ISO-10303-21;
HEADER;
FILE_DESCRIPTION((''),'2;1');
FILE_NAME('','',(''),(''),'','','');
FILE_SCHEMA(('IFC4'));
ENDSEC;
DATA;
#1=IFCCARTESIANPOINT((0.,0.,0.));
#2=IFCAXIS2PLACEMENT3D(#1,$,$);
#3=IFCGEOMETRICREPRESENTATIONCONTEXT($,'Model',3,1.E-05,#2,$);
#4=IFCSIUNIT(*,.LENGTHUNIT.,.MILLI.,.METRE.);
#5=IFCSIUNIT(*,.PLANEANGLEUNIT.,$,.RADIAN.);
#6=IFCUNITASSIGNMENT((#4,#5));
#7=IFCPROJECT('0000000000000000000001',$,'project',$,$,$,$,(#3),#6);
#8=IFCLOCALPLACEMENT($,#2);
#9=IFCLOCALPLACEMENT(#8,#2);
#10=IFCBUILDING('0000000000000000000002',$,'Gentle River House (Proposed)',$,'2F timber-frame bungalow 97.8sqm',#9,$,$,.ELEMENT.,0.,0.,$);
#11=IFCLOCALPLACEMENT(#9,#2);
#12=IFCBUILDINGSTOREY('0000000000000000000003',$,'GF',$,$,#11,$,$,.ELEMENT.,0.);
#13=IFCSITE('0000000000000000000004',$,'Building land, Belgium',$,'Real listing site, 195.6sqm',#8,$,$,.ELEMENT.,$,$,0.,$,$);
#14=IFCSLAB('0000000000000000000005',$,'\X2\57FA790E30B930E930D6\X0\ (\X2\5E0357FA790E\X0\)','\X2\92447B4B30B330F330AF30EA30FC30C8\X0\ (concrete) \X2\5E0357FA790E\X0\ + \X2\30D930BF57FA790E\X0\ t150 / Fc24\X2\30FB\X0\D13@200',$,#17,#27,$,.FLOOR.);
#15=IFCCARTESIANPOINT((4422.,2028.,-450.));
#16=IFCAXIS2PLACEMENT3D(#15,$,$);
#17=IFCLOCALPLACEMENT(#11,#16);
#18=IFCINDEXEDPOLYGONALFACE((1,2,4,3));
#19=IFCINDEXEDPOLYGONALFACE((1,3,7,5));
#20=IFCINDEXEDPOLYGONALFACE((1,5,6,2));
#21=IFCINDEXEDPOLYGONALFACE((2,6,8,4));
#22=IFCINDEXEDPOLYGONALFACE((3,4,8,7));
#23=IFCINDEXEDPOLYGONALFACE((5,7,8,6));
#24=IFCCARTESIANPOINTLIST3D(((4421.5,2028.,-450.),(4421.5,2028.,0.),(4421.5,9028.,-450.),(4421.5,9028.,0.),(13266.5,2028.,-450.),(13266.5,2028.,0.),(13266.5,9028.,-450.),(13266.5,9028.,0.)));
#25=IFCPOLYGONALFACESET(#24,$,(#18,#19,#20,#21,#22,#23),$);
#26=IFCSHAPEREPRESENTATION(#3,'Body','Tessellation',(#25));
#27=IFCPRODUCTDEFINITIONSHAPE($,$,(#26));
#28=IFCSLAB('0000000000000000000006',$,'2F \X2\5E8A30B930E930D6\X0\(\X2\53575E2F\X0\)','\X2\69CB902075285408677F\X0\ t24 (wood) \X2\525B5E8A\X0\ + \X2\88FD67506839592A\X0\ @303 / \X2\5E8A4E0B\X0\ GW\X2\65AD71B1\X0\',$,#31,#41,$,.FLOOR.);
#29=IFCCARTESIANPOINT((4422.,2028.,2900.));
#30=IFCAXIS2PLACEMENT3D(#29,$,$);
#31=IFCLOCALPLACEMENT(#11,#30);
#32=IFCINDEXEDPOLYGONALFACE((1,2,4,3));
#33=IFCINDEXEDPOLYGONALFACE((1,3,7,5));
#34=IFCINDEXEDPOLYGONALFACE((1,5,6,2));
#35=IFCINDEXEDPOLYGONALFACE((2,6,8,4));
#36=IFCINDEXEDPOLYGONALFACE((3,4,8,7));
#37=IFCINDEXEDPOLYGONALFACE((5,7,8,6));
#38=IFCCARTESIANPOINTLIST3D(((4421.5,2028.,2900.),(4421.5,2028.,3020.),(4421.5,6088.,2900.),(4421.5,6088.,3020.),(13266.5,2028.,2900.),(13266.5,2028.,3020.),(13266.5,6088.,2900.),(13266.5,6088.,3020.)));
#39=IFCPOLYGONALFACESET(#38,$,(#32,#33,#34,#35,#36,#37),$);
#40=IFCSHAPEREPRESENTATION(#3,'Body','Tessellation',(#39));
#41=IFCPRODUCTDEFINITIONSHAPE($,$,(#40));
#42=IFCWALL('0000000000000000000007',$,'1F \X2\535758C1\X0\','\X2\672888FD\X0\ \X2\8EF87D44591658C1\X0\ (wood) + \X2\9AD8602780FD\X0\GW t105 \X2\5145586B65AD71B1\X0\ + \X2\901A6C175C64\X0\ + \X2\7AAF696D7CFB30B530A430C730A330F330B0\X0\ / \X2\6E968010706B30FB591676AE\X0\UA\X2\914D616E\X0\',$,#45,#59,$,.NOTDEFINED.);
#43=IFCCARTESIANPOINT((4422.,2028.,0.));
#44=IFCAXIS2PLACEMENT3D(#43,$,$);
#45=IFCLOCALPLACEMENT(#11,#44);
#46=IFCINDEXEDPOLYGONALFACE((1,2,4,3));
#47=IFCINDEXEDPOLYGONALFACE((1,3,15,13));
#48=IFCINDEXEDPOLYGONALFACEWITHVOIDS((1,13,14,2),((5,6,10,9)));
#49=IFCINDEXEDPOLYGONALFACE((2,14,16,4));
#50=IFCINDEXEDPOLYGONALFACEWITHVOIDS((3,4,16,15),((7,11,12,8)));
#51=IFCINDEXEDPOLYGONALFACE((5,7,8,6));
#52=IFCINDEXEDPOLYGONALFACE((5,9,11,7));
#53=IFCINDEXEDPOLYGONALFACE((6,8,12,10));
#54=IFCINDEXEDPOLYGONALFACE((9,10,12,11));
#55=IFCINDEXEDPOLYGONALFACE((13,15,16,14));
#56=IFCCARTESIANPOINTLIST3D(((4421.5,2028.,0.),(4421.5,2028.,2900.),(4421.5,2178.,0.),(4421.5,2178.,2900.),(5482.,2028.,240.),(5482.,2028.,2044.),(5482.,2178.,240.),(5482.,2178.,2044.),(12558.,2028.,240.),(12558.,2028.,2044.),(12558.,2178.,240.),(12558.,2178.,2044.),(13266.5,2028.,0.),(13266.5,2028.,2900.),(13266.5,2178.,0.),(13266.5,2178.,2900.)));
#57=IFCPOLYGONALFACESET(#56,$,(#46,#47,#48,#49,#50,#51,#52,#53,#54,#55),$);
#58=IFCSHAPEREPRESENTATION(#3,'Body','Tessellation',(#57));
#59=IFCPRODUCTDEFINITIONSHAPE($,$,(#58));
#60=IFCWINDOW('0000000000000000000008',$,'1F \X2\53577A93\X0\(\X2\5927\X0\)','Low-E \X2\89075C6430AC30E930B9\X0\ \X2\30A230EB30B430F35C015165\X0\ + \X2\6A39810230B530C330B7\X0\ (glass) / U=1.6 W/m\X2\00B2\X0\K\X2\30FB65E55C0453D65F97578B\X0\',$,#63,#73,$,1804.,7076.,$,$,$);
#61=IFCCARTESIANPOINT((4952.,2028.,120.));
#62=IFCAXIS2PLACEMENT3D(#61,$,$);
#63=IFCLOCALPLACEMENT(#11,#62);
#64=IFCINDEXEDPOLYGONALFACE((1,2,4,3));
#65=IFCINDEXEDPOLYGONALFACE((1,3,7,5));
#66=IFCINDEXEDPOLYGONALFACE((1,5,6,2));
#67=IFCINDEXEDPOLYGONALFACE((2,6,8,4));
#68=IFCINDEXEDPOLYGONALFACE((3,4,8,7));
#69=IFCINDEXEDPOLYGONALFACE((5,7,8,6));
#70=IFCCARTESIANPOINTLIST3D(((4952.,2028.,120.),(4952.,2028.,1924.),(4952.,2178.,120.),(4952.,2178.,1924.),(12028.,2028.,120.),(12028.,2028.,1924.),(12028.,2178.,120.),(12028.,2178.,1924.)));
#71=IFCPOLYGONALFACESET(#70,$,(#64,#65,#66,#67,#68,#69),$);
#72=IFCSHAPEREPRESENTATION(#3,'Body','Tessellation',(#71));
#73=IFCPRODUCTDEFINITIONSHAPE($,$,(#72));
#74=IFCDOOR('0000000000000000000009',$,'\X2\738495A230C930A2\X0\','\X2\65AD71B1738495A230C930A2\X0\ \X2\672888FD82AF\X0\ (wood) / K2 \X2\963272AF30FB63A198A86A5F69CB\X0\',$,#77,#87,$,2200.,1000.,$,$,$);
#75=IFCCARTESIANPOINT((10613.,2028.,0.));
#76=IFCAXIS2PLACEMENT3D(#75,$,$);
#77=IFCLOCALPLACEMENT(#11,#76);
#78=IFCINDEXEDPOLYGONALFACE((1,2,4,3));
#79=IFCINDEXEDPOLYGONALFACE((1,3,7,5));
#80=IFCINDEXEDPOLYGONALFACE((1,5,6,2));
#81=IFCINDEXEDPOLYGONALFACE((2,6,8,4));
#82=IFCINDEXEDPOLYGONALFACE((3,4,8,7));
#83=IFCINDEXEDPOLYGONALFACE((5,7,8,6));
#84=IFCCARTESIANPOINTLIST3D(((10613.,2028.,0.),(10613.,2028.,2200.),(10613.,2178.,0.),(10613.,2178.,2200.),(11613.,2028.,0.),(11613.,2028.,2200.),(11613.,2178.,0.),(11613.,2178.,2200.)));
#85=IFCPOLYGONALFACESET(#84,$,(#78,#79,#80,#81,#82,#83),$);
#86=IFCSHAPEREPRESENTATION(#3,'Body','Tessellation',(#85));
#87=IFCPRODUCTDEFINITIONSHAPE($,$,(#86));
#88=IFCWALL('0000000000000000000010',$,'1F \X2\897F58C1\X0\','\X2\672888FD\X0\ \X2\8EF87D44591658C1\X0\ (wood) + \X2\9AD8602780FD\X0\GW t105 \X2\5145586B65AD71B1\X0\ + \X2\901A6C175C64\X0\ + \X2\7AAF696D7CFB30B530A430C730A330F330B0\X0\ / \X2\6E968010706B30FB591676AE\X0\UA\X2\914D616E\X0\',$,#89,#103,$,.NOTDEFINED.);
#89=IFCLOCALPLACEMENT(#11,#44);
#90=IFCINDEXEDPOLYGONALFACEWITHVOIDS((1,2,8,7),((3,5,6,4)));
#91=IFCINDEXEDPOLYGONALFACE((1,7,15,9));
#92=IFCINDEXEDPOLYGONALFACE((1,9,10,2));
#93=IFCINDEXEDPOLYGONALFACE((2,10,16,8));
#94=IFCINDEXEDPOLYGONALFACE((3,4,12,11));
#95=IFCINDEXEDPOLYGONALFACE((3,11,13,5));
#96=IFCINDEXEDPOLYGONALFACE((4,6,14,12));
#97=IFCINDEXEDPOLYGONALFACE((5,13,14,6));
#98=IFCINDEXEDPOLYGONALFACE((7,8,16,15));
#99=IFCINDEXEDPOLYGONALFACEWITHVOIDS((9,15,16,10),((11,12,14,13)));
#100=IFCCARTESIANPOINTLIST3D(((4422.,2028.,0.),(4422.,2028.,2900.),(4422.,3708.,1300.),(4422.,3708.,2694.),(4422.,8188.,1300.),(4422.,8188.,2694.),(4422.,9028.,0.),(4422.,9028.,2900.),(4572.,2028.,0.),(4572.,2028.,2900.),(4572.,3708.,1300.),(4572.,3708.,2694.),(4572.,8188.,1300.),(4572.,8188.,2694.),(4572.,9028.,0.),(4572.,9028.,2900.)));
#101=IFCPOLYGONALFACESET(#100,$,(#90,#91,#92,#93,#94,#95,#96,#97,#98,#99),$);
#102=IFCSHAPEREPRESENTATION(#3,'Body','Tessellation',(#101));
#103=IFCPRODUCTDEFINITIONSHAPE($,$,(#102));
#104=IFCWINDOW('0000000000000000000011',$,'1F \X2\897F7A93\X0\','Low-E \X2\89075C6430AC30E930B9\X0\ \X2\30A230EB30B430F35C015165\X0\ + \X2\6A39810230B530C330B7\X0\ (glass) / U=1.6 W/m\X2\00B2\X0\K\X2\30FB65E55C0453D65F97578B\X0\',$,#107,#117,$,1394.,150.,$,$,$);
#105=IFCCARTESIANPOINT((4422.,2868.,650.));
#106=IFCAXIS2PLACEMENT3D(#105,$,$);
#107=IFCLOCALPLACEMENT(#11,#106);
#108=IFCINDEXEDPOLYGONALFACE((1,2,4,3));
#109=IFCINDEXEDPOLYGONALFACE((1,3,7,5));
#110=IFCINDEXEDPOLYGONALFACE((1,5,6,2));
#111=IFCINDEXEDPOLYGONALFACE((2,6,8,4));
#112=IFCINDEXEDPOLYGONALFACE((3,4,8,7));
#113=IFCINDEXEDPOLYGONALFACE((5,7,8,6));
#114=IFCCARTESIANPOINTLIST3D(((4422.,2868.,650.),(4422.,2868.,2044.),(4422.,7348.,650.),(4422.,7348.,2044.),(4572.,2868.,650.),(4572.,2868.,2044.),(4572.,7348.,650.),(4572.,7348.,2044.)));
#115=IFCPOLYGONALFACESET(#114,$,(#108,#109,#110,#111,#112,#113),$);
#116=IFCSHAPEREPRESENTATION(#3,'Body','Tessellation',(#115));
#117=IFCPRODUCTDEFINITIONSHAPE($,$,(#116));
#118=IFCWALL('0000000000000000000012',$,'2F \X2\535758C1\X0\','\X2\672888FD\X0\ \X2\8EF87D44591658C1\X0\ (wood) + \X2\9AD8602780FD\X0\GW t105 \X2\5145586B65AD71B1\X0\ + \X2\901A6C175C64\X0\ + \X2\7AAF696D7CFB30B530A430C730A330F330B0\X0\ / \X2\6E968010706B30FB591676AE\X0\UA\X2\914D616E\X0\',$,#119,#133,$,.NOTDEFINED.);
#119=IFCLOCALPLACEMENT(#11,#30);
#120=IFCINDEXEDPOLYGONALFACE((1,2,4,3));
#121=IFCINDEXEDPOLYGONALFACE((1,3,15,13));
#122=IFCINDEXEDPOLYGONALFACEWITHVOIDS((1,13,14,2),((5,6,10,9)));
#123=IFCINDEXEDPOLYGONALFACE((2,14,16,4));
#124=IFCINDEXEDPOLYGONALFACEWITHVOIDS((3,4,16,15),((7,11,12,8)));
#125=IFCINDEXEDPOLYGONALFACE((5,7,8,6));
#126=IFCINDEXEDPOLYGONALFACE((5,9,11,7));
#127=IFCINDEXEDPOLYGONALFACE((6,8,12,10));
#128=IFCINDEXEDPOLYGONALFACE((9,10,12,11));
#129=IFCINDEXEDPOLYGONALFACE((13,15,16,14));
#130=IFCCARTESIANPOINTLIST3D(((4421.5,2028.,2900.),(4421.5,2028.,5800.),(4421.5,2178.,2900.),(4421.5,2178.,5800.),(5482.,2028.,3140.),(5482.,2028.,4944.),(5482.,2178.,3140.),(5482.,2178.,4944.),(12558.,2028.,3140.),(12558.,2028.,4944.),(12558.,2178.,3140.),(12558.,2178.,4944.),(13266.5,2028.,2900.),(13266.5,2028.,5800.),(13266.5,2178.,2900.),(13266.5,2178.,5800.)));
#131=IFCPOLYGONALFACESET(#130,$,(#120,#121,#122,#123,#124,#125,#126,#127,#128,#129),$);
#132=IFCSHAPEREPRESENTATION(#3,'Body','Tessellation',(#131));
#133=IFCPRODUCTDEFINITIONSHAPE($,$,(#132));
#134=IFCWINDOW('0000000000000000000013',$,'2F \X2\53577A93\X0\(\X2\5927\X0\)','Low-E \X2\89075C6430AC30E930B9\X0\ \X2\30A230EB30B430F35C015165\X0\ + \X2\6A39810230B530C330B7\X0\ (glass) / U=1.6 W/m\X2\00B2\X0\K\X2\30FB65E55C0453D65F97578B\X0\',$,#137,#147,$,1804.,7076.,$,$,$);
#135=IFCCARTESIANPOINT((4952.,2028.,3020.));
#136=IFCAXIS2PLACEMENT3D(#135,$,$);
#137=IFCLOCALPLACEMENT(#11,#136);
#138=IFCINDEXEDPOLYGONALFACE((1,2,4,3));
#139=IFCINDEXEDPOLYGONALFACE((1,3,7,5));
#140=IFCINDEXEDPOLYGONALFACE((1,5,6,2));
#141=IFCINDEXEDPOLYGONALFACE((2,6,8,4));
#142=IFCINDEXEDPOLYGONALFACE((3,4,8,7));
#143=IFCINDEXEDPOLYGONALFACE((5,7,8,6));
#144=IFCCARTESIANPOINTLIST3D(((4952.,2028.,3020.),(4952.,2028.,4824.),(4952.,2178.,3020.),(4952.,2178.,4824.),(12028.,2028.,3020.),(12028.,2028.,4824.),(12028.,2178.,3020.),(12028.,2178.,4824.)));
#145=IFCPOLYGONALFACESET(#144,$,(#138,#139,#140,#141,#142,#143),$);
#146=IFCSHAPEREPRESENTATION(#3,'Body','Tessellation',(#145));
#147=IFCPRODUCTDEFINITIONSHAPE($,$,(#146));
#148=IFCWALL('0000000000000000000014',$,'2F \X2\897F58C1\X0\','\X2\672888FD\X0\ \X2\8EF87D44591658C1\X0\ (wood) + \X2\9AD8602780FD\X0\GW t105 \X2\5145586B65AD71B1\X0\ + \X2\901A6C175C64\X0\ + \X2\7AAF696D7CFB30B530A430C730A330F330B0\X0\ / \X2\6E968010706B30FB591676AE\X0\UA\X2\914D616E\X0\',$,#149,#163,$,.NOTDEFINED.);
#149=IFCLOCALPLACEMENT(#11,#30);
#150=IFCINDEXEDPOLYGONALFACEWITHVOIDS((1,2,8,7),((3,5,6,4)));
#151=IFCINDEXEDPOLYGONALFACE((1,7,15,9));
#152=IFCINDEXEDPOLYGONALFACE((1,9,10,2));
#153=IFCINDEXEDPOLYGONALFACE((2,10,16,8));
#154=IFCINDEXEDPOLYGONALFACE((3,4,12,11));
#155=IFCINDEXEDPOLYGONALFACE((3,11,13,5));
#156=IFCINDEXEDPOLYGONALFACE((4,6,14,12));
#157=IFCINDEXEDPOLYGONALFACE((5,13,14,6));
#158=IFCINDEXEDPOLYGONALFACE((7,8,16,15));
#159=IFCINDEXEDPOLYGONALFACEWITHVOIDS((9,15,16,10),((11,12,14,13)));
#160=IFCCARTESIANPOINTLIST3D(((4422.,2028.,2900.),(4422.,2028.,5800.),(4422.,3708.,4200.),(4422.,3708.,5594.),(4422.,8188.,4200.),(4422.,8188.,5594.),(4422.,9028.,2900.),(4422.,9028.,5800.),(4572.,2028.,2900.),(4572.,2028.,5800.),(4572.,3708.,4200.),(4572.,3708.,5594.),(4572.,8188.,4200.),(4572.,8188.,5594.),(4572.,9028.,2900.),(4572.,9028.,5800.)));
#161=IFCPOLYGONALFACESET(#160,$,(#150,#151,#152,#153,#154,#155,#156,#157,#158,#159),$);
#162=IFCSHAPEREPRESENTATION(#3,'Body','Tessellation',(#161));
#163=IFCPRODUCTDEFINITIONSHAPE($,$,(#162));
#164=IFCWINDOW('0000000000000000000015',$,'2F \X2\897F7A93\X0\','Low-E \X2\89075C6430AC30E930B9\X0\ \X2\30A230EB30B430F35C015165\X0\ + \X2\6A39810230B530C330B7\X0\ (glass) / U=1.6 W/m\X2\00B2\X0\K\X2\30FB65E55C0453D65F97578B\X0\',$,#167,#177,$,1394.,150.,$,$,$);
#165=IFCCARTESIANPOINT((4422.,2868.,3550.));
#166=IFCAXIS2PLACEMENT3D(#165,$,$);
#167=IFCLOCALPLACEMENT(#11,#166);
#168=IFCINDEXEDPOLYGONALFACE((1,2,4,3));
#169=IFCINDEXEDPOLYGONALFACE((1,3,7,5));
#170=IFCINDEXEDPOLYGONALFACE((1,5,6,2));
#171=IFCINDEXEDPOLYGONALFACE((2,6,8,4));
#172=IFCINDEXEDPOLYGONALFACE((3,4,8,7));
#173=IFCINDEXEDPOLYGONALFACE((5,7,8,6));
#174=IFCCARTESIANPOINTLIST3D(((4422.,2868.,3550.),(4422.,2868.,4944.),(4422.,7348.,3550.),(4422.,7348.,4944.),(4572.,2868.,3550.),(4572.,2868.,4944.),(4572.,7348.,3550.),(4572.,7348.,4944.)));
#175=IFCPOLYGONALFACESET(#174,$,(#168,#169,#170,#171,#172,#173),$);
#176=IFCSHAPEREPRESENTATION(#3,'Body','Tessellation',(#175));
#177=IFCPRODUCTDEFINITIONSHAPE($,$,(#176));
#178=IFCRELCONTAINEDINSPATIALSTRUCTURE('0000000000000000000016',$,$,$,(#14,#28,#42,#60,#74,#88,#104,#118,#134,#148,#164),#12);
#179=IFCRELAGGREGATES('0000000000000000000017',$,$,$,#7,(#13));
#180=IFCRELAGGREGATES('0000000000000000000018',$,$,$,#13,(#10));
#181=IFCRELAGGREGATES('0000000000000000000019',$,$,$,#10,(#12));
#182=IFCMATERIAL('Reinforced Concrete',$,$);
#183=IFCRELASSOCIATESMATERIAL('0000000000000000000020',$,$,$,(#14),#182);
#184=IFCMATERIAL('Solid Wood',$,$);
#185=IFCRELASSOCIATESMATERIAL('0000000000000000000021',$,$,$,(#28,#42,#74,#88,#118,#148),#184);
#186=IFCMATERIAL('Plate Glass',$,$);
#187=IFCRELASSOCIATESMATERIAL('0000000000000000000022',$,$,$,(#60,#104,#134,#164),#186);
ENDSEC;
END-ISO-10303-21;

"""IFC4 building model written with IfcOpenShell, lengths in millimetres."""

from ifc_helpers import new_model, si_unit, frame, frame_2d, origin, place, context, project, spatial, rectangle, extrude, material, element, fill, save


model = new_model("IFC4")

# Units and contexts
model_context = context("Model", 3, precision=1e-05, world=origin())
ifc_project = project(units=[si_unit("LENGTHUNIT", "METRE", prefix="MILLI"), si_unit("PLANEANGLEUNIT", "RADIAN")], contexts=[model_context])

# Site, building, storey
site_placement = place(None, origin())
site = spatial("IfcSite", under=ifc_project, at=site_placement, Name="Building land, Belgium", ObjectType="Real listing site, 195.6sqm", CompositionType="ELEMENT", RefElevation=0.0)
building_placement = place(site_placement, origin())
building = spatial("IfcBuilding", under=site, at=building_placement, Name="Gentle River House (Proposed)", ObjectType="2F timber-frame bungalow 97.8sqm", CompositionType="ELEMENT", ElevationOfRefHeight=0.0, ElevationOfTerrain=0.0)
storey_placement = place(building_placement, origin())
storey = spatial("IfcBuildingStorey", under=building, at=storey_placement, Name="GF", CompositionType="ELEMENT", Elevation=0.0)

# Slabs
ifc_material_1 = material(Name="Reinforced Concrete")
slab_1_placement = place(storey_placement, frame((4422.0, 2028.0, -450.0)))
element("IfcSlab", 1, at=slab_1_placement, inside=storey, material=ifc_material_1, Name="基礎スラブ (布基礎)", Description="鉄筋コンクリート (concrete) 布基礎 + ベタ基礎 t150 / Fc24・D13@200", PredefinedType="FLOOR", context=model_context, shape_type="SweptSolid", body=[
    extrude(rectangle(XDim=8845.0, YDim=7000.0, at=frame_2d((4422.0, 3500.0))), frame((4422.0, 2028.0, -450.0)), (0.0, 0.0, 1.0), 450.0),
])
ifc_material_2 = material(Name="Solid Wood")
slab_2_placement = place(storey_placement, frame((4422.0, 2028.0, 2900.0)))
element("IfcSlab", 2, at=slab_2_placement, inside=storey, material=ifc_material_2, Name="2F 床スラブ(南帯)", Description="構造用合板 t24 (wood) 剛床 + 製材根太 @303 / 床下 GW断熱", PredefinedType="FLOOR", context=model_context, shape_type="SweptSolid", body=[
    extrude(rectangle(XDim=8845.0, YDim=4060.0, at=frame_2d((4422.0, 2030.0))), frame((4422.0, 2028.0, 2900.0)), (0.0, 0.0, 1.0), 120.0),
])

# Wall, openings, window, door
wall_1_placement = place(storey_placement, frame((4422.0, 2028.0, 0.0)))
wall_1 = element("IfcWall", 3, at=wall_1_placement, inside=storey, material=ifc_material_2, Name="1F 南壁", Description="木製 軸組外壁 (wood) + 高性能GW t105 充填断熱 + 通気層 + 窯業系サイディング / 準耐火・外皮UA配慮", PredefinedType="NOTDEFINED", context=model_context, shape_type="SweptSolid", body=[
    extrude(rectangle(XDim=8845.0, YDim=150.0, at=frame_2d((4422.0, 75.0))), frame((4422.0, 2028.0, 0.0)), (0.0, 0.0, 1.0), 2900.0),
])
opening_1_placement = place(storey_placement, frame((4952.0, 2028.0, 120.0)))
opening_1 = element("IfcOpeningElement", 4, at=opening_1_placement, cuts=wall_1, PredefinedType="NOTDEFINED", context=model_context, shape_type="SweptSolid", body=[
    extrude(rectangle(XDim=7076.0, YDim=150.0, at=frame_2d((3538.0, 75.0))), frame((4952.0, 2028.0, 120.0)), (0.0, 0.0, 1.0), 1804.0),
])
opening_2_placement = place(storey_placement, frame((10613.0, 2028.0, 0.0)))
opening_2 = element("IfcOpeningElement", 5, at=opening_2_placement, cuts=wall_1, PredefinedType="NOTDEFINED", context=model_context, shape_type="SweptSolid", body=[
    extrude(rectangle(XDim=1000.0, YDim=150.0, at=frame_2d((500.0, 75.0))), frame((10613.0, 2028.0, 0.0)), (0.0, 0.0, 1.0), 2200.0),
])
ifc_material_3 = material(Name="Plate Glass")
window_1_placement = place(storey_placement, frame((4952.0, 2028.0, 120.0)))
window_1 = element("IfcWindow", 6, at=window_1_placement, inside=storey, material=ifc_material_3, Name="1F 南窓(大)", Description="Low-E 複層ガラス アルゴン封入 + 樹脂サッシ (glass) / U=1.6 W/m²K・日射取得型", OverallHeight=1804.0, OverallWidth=7076.0, context=model_context, shape_type="SweptSolid", body=[
    extrude(rectangle(XDim=7076.0, YDim=150.0, at=frame_2d((3538.0, 75.0))), frame((4952.0, 2028.0, 120.0)), (0.0, 0.0, 1.0), 1804.0),
])
fill(opening_1, window_1)
door_placement = place(storey_placement, frame((10613.0, 2028.0, 0.0)))
door = element("IfcDoor", 7, at=door_placement, inside=storey, material=ifc_material_2, Name="玄関ドア", Description="断熱玄関ドア 木製芯 (wood) / K2 防犯・採風機構", OverallHeight=2200.0, OverallWidth=1000.0, context=model_context, shape_type="SweptSolid", body=[
    extrude(rectangle(XDim=1000.0, YDim=150.0, at=frame_2d((500.0, 75.0))), frame((10613.0, 2028.0, 0.0)), (0.0, 0.0, 1.0), 2200.0),
])
fill(opening_2, door)

# Wall, opening, window
wall_2_placement = place(storey_placement, frame((4422.0, 2028.0, 0.0)))
wall_2 = element("IfcWall", 8, at=wall_2_placement, inside=storey, material=ifc_material_2, Name="1F 西壁", Description="木製 軸組外壁 (wood) + 高性能GW t105 充填断熱 + 通気層 + 窯業系サイディング / 準耐火・外皮UA配慮", PredefinedType="NOTDEFINED", context=model_context, shape_type="SweptSolid", body=[
    extrude(rectangle(XDim=150.0, YDim=7000.0, at=frame_2d((75.0, 3500.0))), frame((4422.0, 2028.0, 0.0)), (0.0, 0.0, 1.0), 2900.0),
])
opening_3_placement = place(storey_placement, frame((4422.0, 2868.0, 650.0)))
opening_3 = element("IfcOpeningElement", 9, at=opening_3_placement, cuts=wall_2, PredefinedType="NOTDEFINED", context=model_context, shape_type="SweptSolid", body=[
    extrude(rectangle(XDim=150.0, YDim=4480.0, at=frame_2d((75.0, 2240.0))), frame((4422.0, 2868.0, 650.0)), (0.0, 0.0, 1.0), 1394.0),
])
window_2_placement = place(storey_placement, frame((4422.0, 2868.0, 650.0)))
window_2 = element("IfcWindow", 10, at=window_2_placement, inside=storey, material=ifc_material_3, Name="1F 西窓", Description="Low-E 複層ガラス アルゴン封入 + 樹脂サッシ (glass) / U=1.6 W/m²K・日射取得型", OverallHeight=1394.0, OverallWidth=150.0, context=model_context, shape_type="SweptSolid", body=[
    extrude(rectangle(XDim=150.0, YDim=4480.0, at=frame_2d((75.0, 2240.0))), frame((4422.0, 2868.0, 650.0)), (0.0, 0.0, 1.0), 1394.0),
])
fill(opening_3, window_2)

# Walls, openings, windows
wall_3_placement = place(storey_placement, frame((4422.0, 2028.0, 2900.0)))
wall_3 = element("IfcWall", 11, at=wall_3_placement, inside=storey, material=ifc_material_2, Name="2F 南壁", Description="木製 軸組外壁 (wood) + 高性能GW t105 充填断熱 + 通気層 + 窯業系サイディング / 準耐火・外皮UA配慮", PredefinedType="NOTDEFINED", context=model_context, shape_type="SweptSolid", body=[
    extrude(rectangle(XDim=8845.0, YDim=150.0, at=frame_2d((4422.0, 75.0))), frame((4422.0, 2028.0, 2900.0)), (0.0, 0.0, 1.0), 2900.0),
])
opening_4_placement = place(storey_placement, frame((4952.0, 2028.0, 3020.0)))
opening_4 = element("IfcOpeningElement", 12, at=opening_4_placement, cuts=wall_3, PredefinedType="NOTDEFINED", context=model_context, shape_type="SweptSolid", body=[
    extrude(rectangle(XDim=7076.0, YDim=150.0, at=frame_2d((3538.0, 75.0))), frame((4952.0, 2028.0, 3020.0)), (0.0, 0.0, 1.0), 1804.0),
])
window_3_placement = place(storey_placement, frame((4952.0, 2028.0, 3020.0)))
window_3 = element("IfcWindow", 13, at=window_3_placement, inside=storey, material=ifc_material_3, Name="2F 南窓(大)", Description="Low-E 複層ガラス アルゴン封入 + 樹脂サッシ (glass) / U=1.6 W/m²K・日射取得型", OverallHeight=1804.0, OverallWidth=7076.0, context=model_context, shape_type="SweptSolid", body=[
    extrude(rectangle(XDim=7076.0, YDim=150.0, at=frame_2d((3538.0, 75.0))), frame((4952.0, 2028.0, 3020.0)), (0.0, 0.0, 1.0), 1804.0),
])
fill(opening_4, window_3)
wall_4_placement = place(storey_placement, frame((4422.0, 2028.0, 2900.0)))
wall_4 = element("IfcWall", 14, at=wall_4_placement, inside=storey, material=ifc_material_2, Name="2F 西壁", Description="木製 軸組外壁 (wood) + 高性能GW t105 充填断熱 + 通気層 + 窯業系サイディング / 準耐火・外皮UA配慮", PredefinedType="NOTDEFINED", context=model_context, shape_type="SweptSolid", body=[
    extrude(rectangle(XDim=150.0, YDim=7000.0, at=frame_2d((75.0, 3500.0))), frame((4422.0, 2028.0, 2900.0)), (0.0, 0.0, 1.0), 2900.0),
])
opening_5_placement = place(storey_placement, frame((4422.0, 2868.0, 3550.0)))
opening_5 = element("IfcOpeningElement", 15, at=opening_5_placement, cuts=wall_4, PredefinedType="NOTDEFINED", context=model_context, shape_type="SweptSolid", body=[
    extrude(rectangle(XDim=150.0, YDim=4480.0, at=frame_2d((75.0, 2240.0))), frame((4422.0, 2868.0, 3550.0)), (0.0, 0.0, 1.0), 1394.0),
])
window_4_placement = place(storey_placement, frame((4422.0, 2868.0, 3550.0)))
window_4 = element("IfcWindow", 16, at=window_4_placement, inside=storey, material=ifc_material_3, Name="2F 西窓", Description="Low-E 複層ガラス アルゴン封入 + 樹脂サッシ (glass) / U=1.6 W/m²K・日射取得型", OverallHeight=1394.0, OverallWidth=150.0, context=model_context, shape_type="SweptSolid", body=[
    extrude(rectangle(XDim=150.0, YDim=4480.0, at=frame_2d((75.0, 2240.0))), frame((4422.0, 2868.0, 3550.0)), (0.0, 0.0, 1.0), 1394.0),
])
fill(opening_5, window_4)

save(model, "model.ifc")
